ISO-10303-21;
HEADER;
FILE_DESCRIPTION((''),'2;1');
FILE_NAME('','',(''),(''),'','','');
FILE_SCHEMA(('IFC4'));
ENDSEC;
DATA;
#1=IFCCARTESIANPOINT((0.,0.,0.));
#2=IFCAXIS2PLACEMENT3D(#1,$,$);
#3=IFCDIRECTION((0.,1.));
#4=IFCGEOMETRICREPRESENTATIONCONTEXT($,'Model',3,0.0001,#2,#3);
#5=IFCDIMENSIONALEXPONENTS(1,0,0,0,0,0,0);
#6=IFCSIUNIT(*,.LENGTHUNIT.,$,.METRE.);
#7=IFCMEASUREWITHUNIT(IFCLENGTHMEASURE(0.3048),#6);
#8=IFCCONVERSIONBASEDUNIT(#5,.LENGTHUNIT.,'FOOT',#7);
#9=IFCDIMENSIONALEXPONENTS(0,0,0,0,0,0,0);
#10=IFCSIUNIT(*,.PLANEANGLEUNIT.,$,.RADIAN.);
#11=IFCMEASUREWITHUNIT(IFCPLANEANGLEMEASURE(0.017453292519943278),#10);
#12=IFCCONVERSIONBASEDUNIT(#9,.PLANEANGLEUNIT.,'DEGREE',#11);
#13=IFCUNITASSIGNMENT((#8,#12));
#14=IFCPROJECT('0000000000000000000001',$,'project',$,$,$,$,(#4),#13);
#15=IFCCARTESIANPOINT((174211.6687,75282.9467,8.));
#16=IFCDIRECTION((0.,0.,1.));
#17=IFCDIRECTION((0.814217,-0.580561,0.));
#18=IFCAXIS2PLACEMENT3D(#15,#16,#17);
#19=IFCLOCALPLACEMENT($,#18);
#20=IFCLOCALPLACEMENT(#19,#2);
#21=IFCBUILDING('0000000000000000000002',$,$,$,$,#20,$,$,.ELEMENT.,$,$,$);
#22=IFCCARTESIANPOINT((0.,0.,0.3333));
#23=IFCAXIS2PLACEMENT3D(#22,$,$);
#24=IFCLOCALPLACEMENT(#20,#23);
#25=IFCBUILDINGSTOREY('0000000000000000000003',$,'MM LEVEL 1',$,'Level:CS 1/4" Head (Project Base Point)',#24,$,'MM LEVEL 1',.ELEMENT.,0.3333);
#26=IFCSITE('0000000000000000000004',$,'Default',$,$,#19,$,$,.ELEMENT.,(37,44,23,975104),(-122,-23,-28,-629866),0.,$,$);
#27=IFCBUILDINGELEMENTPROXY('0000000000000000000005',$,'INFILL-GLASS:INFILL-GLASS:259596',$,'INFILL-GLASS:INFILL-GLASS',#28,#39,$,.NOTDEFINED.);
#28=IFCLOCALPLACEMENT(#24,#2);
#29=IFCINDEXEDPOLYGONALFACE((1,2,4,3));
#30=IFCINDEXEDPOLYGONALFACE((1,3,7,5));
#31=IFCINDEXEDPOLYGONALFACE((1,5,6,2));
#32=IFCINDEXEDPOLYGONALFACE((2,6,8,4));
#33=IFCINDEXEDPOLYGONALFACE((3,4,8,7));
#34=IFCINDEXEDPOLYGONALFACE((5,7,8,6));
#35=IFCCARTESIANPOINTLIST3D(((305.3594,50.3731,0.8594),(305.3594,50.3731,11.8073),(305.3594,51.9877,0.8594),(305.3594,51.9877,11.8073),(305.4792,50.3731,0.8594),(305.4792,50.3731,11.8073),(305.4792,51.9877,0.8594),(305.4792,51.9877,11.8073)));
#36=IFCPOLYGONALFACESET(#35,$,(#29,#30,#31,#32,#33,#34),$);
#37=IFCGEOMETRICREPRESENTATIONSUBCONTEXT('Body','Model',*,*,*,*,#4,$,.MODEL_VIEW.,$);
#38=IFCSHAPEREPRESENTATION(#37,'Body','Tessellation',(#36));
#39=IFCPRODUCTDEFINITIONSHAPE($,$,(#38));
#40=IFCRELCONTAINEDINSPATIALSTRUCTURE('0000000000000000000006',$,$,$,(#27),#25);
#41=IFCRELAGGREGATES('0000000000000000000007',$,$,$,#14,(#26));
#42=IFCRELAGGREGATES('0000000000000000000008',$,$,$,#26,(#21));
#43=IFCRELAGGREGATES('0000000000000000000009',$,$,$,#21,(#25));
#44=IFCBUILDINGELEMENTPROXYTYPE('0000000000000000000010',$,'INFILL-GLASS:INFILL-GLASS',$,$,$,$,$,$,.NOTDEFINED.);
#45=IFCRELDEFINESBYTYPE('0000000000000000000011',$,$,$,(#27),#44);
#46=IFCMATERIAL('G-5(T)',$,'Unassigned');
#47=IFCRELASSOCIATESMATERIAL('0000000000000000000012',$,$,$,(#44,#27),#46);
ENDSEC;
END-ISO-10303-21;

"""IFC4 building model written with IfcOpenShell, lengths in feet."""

from ifc_helpers import new_model, entity, si_unit, converted_unit, direction, frame, origin, place, context, subcontext, project, spatial, indexed_curve, outline, extrude, source, transform, mapped, material, type_object, type_shapes, element, save


model = new_model("IFC4")

# Units and contexts
model_context = context("Model", 3, precision=0.0001, world=origin(), true_north=direction((0.0, 1.0)))
body_context = subcontext(model_context, "Body", "Model", "MODEL_VIEW")
ifc_project = project(units=[converted_unit("LENGTHUNIT", "FOOT", entity("IfcLengthMeasure", 0.3048), si_unit("LENGTHUNIT", "METRE"), dimensions=[1, 0, 0, 0, 0, 0, 0]), converted_unit("PLANEANGLEUNIT", "DEGREE", entity("IfcPlaneAngleMeasure", 0.017453292519943278), si_unit("PLANEANGLEUNIT", "RADIAN"), dimensions=[0, 0, 0, 0, 0, 0, 0])], contexts=[model_context])

# Site, building, storey
site_placement = place(None, frame((174211.6687, 75282.9467, 8.0), z_axis=(0.0, 0.0, 1.0), x_axis=(0.814217, -0.580561, 0.0)))
site = spatial("IfcSite", under=ifc_project, at=site_placement, Name="Default", CompositionType="ELEMENT", RefLatitude=(37, 44, 23, 975104), RefLongitude=(-122, -23, -28, -629866), RefElevation=0.0)
building_placement = place(site_placement, origin())
building = spatial("IfcBuilding", under=site, at=building_placement, CompositionType="ELEMENT")
storey_placement = place(building_placement, frame((0.0, 0.0, 0.3333)))
storey = spatial("IfcBuildingStorey", under=building, at=storey_placement, Name="MM LEVEL 1", ObjectType="Level:CS 1/4\" Head (Project Base Point)", LongName="MM LEVEL 1", CompositionType="ELEMENT", Elevation=0.3333)

# Building element proxy
ifc_material_1 = material(Name="G-5(T)", Category="Unassigned")
building_element_proxy_type_1 = type_object("IfcBuildingElementProxyType", Name="INFILL-GLASS:INFILL-GLASS", PredefinedType="NOTDEFINED", material=ifc_material_1)
shared_shape_1 = source(origin(), body_context, "Body", "SweptSolid", [
    extrude(outline(indexed_curve([(-0.0599, -0.8073), (0.0599, -0.8073), (0.0599, 0.8073), (-0.0599, 0.8073), (-0.0599, -0.8073)], self_intersect=False)), frame((0.0, 0.1016, 0.1302), z_axis=(0.0, 0.0, 1.0), x_axis=(0.0, 1.0, 0.0)), (0.0, 0.0, 1.0), 10.9479),
])
type_shapes(building_element_proxy_type_1, [shared_shape_1])
proxy_1_placement = place(storey_placement, frame((305.5208, 51.1804, 0.7292), z_axis=(0.0, 0.0, 1.0), x_axis=(0.0, 1.0, 0.0)))
element("IfcBuildingElementProxy", 1, at=proxy_1_placement, inside=storey, type_object=building_element_proxy_type_1, material=ifc_material_1, Name="INFILL-GLASS:INFILL-GLASS:259596", ObjectType="INFILL-GLASS:INFILL-GLASS", PredefinedType="NOTDEFINED", context=body_context, shape_type="MappedRepresentation", body=[
    mapped(shared_shape_1, transform((0.0, 0.0, 0.0), scale=1.0)),
])

save(model, "model.ifc")
